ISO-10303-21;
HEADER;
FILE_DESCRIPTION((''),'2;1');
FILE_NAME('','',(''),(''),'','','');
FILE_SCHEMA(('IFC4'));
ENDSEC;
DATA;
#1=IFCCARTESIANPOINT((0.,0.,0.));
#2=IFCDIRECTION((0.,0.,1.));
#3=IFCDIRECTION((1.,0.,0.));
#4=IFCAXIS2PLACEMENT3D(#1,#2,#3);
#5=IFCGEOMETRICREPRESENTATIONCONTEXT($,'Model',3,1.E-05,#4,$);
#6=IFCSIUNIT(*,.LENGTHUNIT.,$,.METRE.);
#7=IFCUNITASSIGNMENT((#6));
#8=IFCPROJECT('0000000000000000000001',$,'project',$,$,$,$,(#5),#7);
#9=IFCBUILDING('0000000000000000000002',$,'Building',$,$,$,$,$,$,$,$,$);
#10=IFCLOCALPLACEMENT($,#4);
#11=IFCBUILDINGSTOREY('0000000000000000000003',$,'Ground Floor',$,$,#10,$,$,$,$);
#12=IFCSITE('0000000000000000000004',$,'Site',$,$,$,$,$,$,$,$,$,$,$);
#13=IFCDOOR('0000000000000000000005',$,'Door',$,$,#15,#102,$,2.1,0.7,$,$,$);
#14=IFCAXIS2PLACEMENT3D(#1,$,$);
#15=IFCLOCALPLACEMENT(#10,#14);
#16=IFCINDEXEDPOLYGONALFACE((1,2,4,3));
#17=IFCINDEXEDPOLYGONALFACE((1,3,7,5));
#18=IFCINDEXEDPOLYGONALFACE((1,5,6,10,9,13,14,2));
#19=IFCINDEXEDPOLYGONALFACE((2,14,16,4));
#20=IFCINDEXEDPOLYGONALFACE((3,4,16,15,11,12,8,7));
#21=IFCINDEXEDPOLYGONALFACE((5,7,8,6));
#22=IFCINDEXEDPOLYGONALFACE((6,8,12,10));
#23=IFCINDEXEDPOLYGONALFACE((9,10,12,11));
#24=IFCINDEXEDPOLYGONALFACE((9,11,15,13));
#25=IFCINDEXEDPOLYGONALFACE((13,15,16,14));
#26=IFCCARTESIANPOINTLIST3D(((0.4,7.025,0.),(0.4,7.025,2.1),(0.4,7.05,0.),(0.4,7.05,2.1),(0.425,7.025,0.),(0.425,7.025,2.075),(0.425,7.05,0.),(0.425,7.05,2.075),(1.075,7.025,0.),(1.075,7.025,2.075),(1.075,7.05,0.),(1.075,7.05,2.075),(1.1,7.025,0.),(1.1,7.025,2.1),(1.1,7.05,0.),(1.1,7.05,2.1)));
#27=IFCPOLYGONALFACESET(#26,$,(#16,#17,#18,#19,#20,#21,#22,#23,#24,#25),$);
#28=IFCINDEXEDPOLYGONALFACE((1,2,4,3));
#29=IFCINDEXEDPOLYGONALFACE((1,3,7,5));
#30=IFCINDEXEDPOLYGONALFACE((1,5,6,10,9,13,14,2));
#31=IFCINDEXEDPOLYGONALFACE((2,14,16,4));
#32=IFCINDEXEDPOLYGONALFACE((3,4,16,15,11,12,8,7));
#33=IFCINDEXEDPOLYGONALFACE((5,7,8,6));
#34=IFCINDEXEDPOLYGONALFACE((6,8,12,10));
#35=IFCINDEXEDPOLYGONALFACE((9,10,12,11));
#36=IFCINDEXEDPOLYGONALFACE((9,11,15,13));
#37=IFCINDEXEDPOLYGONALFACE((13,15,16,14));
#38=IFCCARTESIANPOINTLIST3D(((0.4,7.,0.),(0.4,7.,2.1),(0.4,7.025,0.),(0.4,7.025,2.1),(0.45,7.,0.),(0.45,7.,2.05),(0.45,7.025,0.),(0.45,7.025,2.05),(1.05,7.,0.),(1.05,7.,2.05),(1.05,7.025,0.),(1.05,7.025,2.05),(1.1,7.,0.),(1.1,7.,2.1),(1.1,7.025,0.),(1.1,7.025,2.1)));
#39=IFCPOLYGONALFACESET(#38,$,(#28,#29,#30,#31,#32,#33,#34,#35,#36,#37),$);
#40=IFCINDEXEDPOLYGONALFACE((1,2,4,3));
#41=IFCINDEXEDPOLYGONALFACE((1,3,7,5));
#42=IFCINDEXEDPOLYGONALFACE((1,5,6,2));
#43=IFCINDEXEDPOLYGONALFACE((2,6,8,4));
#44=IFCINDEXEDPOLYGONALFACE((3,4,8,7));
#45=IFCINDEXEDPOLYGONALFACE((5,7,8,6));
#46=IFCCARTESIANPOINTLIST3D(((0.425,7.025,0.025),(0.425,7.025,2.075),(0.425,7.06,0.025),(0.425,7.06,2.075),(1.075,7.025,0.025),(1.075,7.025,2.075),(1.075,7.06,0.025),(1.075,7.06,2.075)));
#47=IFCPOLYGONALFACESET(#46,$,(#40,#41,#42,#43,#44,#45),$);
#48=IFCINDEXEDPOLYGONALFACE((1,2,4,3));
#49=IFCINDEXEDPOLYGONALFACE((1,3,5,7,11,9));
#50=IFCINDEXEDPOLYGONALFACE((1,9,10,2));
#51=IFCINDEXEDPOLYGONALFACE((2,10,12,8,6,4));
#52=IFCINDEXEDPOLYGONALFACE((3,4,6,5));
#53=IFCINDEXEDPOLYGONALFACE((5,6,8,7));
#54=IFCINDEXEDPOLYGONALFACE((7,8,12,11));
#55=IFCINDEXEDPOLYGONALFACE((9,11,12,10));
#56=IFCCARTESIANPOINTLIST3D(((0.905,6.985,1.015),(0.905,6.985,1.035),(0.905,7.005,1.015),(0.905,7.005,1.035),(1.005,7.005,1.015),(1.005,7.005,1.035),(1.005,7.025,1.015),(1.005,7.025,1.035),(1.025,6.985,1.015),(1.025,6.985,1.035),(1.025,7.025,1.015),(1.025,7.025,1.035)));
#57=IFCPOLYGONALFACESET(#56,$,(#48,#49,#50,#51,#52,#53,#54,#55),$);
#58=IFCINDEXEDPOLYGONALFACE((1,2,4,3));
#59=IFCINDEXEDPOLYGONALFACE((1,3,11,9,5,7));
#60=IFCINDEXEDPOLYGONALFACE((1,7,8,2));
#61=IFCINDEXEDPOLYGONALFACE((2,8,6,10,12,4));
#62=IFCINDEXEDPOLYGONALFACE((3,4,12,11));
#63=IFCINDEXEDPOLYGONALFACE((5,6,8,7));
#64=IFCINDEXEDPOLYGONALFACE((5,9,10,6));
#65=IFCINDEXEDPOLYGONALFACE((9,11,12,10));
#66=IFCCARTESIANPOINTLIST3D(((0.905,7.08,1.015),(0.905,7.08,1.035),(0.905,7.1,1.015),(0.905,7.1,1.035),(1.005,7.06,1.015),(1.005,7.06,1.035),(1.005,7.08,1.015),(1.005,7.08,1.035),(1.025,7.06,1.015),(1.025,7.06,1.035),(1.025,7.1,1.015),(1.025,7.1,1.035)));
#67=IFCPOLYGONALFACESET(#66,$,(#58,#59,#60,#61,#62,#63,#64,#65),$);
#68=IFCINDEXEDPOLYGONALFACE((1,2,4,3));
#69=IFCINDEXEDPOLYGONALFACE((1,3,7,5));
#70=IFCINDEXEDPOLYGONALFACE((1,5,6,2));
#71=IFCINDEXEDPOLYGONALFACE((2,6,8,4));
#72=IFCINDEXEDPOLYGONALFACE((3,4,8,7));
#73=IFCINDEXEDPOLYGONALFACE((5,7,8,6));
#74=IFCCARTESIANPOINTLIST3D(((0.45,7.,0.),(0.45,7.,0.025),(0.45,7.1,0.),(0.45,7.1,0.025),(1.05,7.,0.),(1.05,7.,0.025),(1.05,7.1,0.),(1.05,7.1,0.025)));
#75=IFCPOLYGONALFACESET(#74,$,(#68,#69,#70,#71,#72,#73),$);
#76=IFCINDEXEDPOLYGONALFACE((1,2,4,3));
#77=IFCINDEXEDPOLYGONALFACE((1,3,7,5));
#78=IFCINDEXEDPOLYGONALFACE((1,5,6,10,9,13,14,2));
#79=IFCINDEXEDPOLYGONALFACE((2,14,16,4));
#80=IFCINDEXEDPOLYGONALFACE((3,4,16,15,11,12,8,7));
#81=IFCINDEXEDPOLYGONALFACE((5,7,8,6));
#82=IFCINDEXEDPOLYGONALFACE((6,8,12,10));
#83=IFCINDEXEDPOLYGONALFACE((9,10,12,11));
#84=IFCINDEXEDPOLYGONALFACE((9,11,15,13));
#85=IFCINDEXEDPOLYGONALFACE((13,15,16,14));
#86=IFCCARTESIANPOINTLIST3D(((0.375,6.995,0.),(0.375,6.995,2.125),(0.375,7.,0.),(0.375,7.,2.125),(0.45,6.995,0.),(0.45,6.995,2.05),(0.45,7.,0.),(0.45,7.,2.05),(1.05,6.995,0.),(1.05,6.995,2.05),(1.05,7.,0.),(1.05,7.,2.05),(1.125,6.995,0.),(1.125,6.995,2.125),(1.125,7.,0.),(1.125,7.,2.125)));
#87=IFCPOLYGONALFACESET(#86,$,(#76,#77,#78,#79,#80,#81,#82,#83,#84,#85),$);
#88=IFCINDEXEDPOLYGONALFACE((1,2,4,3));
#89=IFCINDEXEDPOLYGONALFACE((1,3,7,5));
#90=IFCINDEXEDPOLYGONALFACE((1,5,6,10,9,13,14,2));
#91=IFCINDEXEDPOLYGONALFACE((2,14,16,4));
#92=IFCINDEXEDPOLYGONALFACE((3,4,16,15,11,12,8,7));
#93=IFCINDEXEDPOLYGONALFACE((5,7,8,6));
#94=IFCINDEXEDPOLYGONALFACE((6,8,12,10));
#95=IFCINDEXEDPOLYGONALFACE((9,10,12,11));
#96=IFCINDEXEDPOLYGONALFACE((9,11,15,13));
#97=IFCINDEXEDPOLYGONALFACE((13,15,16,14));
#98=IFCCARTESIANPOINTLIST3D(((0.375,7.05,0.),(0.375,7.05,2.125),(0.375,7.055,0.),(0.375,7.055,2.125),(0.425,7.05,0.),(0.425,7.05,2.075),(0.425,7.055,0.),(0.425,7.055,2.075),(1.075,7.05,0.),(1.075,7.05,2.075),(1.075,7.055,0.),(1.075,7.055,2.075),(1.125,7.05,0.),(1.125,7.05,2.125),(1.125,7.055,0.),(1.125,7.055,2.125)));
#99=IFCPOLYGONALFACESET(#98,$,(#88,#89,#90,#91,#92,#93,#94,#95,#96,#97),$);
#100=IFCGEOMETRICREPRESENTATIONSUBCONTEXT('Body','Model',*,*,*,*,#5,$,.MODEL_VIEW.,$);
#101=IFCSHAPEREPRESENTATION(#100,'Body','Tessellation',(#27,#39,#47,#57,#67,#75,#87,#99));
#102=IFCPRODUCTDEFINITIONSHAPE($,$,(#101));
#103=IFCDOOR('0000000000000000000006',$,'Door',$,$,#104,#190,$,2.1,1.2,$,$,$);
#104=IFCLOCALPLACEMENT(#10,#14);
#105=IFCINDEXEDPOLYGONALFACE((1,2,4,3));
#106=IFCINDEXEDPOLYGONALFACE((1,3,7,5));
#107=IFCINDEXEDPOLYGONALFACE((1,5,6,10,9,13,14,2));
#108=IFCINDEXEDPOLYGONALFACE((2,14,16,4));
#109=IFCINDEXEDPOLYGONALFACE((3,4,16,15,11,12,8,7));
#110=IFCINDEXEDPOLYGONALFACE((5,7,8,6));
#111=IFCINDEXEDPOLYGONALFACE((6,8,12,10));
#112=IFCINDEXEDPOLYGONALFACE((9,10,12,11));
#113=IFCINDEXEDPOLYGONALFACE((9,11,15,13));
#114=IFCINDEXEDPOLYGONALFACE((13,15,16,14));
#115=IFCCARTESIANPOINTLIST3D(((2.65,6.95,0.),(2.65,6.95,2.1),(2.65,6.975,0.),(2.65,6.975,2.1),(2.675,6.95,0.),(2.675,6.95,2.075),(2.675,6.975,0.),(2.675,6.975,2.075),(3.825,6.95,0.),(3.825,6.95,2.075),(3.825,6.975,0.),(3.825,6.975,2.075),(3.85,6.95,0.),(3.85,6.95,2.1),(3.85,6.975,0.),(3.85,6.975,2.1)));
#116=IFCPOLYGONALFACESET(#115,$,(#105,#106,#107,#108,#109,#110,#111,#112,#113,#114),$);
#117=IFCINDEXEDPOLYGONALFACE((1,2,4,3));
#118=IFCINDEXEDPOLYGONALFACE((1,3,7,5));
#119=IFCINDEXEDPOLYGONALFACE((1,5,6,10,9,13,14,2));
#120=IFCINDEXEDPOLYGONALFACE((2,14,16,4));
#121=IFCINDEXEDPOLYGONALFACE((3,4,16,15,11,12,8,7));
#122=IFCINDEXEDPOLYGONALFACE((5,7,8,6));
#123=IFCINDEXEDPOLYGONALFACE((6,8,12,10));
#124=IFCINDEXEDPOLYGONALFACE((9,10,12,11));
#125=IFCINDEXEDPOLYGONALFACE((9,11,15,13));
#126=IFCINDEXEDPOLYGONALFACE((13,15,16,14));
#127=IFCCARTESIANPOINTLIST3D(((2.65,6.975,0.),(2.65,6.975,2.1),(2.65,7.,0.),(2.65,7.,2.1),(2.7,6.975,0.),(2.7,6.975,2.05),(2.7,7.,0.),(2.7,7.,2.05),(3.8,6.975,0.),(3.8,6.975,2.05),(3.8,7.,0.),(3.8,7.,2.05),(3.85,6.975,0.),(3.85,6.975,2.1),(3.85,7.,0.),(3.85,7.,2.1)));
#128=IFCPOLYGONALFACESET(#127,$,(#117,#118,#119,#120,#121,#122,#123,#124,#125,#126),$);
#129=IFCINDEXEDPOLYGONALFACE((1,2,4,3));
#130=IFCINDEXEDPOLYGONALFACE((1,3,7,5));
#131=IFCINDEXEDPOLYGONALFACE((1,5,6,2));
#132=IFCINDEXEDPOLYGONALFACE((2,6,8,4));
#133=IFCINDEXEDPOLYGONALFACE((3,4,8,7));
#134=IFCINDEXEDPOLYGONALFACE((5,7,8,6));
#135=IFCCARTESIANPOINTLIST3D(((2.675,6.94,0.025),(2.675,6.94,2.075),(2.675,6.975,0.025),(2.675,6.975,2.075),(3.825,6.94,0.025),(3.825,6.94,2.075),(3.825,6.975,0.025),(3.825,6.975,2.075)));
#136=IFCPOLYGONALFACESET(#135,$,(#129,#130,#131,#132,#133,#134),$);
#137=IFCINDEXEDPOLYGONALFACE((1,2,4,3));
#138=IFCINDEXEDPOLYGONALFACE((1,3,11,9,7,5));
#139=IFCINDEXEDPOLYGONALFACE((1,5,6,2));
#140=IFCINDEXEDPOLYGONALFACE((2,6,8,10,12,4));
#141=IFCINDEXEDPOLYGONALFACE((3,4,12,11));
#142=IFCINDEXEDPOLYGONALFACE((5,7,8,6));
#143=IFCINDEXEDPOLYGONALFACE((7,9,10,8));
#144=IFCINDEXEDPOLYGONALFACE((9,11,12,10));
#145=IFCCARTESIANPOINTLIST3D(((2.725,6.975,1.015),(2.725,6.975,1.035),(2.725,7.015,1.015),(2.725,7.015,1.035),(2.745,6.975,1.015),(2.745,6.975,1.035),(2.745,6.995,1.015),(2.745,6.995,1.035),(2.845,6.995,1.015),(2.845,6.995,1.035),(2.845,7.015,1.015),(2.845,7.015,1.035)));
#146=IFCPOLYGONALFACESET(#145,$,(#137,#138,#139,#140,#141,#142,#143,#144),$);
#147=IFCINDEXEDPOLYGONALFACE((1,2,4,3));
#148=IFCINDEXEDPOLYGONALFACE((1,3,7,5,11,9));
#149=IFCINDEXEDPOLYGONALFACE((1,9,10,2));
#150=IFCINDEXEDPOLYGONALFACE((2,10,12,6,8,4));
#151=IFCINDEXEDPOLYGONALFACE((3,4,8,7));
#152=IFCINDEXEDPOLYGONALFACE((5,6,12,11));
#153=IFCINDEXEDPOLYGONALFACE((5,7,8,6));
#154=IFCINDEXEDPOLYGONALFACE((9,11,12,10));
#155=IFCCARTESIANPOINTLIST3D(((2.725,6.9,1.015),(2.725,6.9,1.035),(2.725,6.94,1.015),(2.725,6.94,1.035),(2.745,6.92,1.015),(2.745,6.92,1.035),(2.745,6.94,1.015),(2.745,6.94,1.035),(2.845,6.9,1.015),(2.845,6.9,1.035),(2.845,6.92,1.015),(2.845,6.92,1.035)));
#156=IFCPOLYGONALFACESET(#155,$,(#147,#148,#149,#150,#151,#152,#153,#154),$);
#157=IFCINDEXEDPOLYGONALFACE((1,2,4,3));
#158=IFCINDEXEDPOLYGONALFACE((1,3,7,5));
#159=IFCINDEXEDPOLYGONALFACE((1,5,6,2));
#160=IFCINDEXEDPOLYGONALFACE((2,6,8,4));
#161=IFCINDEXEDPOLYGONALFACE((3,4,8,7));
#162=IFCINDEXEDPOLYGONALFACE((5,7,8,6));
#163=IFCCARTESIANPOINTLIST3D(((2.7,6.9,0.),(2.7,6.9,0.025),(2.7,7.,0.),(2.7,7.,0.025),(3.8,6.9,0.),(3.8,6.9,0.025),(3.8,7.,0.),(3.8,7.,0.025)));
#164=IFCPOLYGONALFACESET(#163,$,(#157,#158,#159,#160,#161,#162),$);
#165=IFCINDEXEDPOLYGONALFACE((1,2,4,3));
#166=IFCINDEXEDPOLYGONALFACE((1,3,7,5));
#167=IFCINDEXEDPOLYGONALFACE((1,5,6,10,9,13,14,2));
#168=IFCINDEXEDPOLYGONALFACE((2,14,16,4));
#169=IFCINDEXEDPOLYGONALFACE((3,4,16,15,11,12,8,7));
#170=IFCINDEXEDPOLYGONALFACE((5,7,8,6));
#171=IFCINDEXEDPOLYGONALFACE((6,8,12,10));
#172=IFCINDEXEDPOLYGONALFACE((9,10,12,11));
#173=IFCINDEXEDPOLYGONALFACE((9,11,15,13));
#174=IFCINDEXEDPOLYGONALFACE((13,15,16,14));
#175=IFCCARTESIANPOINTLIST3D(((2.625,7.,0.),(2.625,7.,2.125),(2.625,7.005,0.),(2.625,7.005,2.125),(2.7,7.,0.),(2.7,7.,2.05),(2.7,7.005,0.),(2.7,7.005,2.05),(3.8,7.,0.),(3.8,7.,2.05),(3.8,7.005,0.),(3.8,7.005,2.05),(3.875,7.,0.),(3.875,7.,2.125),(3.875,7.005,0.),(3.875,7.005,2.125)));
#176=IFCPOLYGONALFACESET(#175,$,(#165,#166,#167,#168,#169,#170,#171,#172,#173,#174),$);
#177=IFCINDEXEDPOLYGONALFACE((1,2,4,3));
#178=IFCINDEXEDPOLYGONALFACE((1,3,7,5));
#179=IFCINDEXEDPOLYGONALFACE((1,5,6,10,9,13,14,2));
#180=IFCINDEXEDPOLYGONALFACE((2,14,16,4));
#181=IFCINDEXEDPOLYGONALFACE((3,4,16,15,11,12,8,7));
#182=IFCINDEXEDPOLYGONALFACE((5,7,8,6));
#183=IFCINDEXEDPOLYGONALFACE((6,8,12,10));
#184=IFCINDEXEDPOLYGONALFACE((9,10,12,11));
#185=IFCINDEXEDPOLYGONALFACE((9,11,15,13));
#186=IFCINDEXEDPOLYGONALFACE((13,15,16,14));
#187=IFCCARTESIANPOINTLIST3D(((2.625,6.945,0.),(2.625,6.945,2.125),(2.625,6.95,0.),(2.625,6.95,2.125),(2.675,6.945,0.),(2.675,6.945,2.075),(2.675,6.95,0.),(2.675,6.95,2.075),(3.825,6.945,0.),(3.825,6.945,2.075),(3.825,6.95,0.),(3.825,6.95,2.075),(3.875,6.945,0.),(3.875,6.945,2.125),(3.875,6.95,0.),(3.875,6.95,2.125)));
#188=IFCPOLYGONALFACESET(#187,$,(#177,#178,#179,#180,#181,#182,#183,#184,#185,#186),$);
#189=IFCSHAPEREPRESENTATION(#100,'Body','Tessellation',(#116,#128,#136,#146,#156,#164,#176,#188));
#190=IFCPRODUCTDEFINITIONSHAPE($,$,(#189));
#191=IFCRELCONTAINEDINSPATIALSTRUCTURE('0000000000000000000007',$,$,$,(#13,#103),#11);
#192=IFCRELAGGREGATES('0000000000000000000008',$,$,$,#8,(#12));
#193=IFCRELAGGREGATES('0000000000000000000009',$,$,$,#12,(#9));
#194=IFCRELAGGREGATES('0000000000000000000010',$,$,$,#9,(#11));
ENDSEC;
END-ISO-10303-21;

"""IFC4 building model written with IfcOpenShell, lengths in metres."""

from ifc_helpers import new_model, si_unit, frame, origin_with_axes, place, context, subcontext, project, spatial, line, indexed_curve, outline, extrude, element, save


model = new_model("IFC4")

# Units and contexts
model_context = context("Model", 3, precision=1e-05, world=origin_with_axes())
body_context = subcontext(model_context, "Body", "Model", "MODEL_VIEW")
ifc_project = project(units=[si_unit("LENGTHUNIT", "METRE")], contexts=[model_context])

# Site, building, storey
site = spatial("IfcSite", under=ifc_project, Name="Site")
building = spatial("IfcBuilding", under=site, Name="Building")
storey_placement = place(None, origin_with_axes())
storey = spatial("IfcBuildingStorey", under=building, at=storey_placement, Name="Ground Floor")

# Doors
door_1_placement = place(storey_placement, frame((0.4, 7.0, 0.0), z_axis=(0.0, 0.0, 1.0), x_axis=(1.0, 0.0, 0.0)))
element("IfcDoor", 1, at=door_1_placement, inside=storey, Name="Door", OverallHeight=2.1, OverallWidth=0.7, context=body_context, shape_type="SweptSolid", body=[
    extrude(outline(indexed_curve([(0.0, 0.0), (0.0, 2.1), (0.7, 2.1), (0.7, 0.0), (0.675, 0.0), (0.675, 2.075), (0.025, 2.075), (0.025, 0.0)], segments=[line(1, 2, 3, 4, 5, 6, 7, 8, 1)])), frame((0.0, 0.025, 0.0), z_axis=(0.0, -1.0, 0.0), x_axis=(1.0, 0.0, 0.0)), (0.0, 0.0, -1.0), 0.025),
    extrude(outline(indexed_curve([(0.0, 0.0), (0.0, 2.1), (0.7, 2.1), (0.7, 0.0), (0.65, 0.0), (0.65, 2.05), (0.05, 2.05), (0.05, 0.0)], segments=[line(1, 2, 3, 4, 5, 6, 7, 8, 1)])), frame((0.0, 0.0, 0.0), z_axis=(0.0, -1.0, 0.0), x_axis=(1.0, 0.0, 0.0)), (0.0, 0.0, -1.0), 0.025),
    extrude(outline(indexed_curve([(0.0, 0.0), (0.65, 0.0), (0.65, 0.035), (0.0, 0.035)], segments=[line(1, 2, 3, 4, 1)])), frame((0.025, 0.025, 0.025), z_axis=(0.0, 0.0, 1.0), x_axis=(1.0, 0.0, 0.0)), (0.0, 0.0, 1.0), 2.05),
    extrude(outline(indexed_curve([(0.0, 0.0), (0.0, -0.04), (-0.12, -0.04), (-0.12, -0.02), (-0.02, -0.02), (-0.02, 0.0)], segments=[line(1, 2, 3, 4, 5, 6, 1)])), frame((0.625, 0.025, 1.015), z_axis=(0.0, 0.0, 1.0), x_axis=(1.0, 0.0, 0.0)), (0.0, 0.0, 1.0), 0.02),
    extrude(outline(indexed_curve([(0.0, 0.0), (0.0, 0.04), (-0.12, 0.04), (-0.12, 0.02), (-0.02, 0.02), (-0.02, 0.0)], segments=[line(1, 2, 3, 4, 5, 6, 1)])), frame((0.625, 0.06, 1.015), z_axis=(0.0, 0.0, 1.0), x_axis=(1.0, 0.0, 0.0)), (0.0, 0.0, 1.0), 0.02),
    extrude(outline(indexed_curve([(0.0, 0.0), (0.6, 0.0), (0.6, 0.1), (0.0, 0.1)], segments=[line(1, 2, 3, 4, 1)])), frame((0.05, 0.0, 0.0), z_axis=(0.0, 0.0, 1.0), x_axis=(1.0, 0.0, 0.0)), (0.0, 0.0, 1.0), 0.025),
    extrude(outline(indexed_curve([(0.0, 0.0), (0.0, 2.125), (0.75, 2.125), (0.75, 0.0), (0.675, 0.0), (0.675, 2.05), (0.075, 2.05), (0.075, 0.0)], segments=[line(1, 2, 3, 4, 5, 6, 7, 8, 1)])), frame((-0.025, -0.005, 0.0), z_axis=(0.0, -1.0, 0.0), x_axis=(1.0, 0.0, 0.0)), (0.0, 0.0, -1.0), 0.005),
    extrude(outline(indexed_curve([(0.0, 0.0), (0.0, 2.125), (0.75, 2.125), (0.75, 0.0), (0.7, 0.0), (0.7, 2.075), (0.05, 2.075), (0.05, 0.0)], segments=[line(1, 2, 3, 4, 5, 6, 7, 8, 1)])), frame((-0.025, 0.05, 0.0), z_axis=(0.0, -1.0, 0.0), x_axis=(1.0, 0.0, 0.0)), (0.0, 0.0, -1.0), 0.005),
])
door_2_placement = place(storey_placement, frame((3.85, 7.0, 0.0), z_axis=(0.0, 0.0, 1.0), x_axis=(-1.0, 0.0, 0.0)))
element("IfcDoor", 2, at=door_2_placement, inside=storey, Name="Door", OverallHeight=2.1, OverallWidth=1.2, context=body_context, shape_type="SweptSolid", body=[
    extrude(outline(indexed_curve([(0.0, 0.0), (0.0, 2.1), (1.2, 2.1), (1.2, 0.0), (1.175, 0.0), (1.175, 2.075), (0.025, 2.075), (0.025, 0.0)], segments=[line(1, 2, 3, 4, 5, 6, 7, 8, 1)])), frame((0.0, 0.025, 0.0), z_axis=(0.0, -1.0, 0.0), x_axis=(1.0, 0.0, 0.0)), (0.0, 0.0, -1.0), 0.025),
    extrude(outline(indexed_curve([(0.0, 0.0), (0.0, 2.1), (1.2, 2.1), (1.2, 0.0), (1.15, 0.0), (1.15, 2.05), (0.05, 2.05), (0.05, 0.0)], segments=[line(1, 2, 3, 4, 5, 6, 7, 8, 1)])), frame((0.0, 0.0, 0.0), z_axis=(0.0, -1.0, 0.0), x_axis=(1.0, 0.0, 0.0)), (0.0, 0.0, -1.0), 0.025),
    extrude(outline(indexed_curve([(0.0, 0.0), (1.15, 0.0), (1.15, 0.035), (0.0, 0.035)], segments=[line(1, 2, 3, 4, 1)])), frame((0.025, 0.025, 0.025), z_axis=(0.0, 0.0, 1.0), x_axis=(1.0, 0.0, 0.0)), (0.0, 0.0, 1.0), 2.05),
    extrude(outline(indexed_curve([(0.0, 0.0), (0.0, -0.04), (-0.12, -0.04), (-0.12, -0.02), (-0.02, -0.02), (-0.02, 0.0)], segments=[line(1, 2, 3, 4, 5, 6, 1)])), frame((1.125, 0.025, 1.015), z_axis=(0.0, 0.0, 1.0), x_axis=(1.0, 0.0, 0.0)), (0.0, 0.0, 1.0), 0.02),
    extrude(outline(indexed_curve([(0.0, 0.0), (0.0, 0.04), (-0.12, 0.04), (-0.12, 0.02), (-0.02, 0.02), (-0.02, 0.0)], segments=[line(1, 2, 3, 4, 5, 6, 1)])), frame((1.125, 0.06, 1.015), z_axis=(0.0, 0.0, 1.0), x_axis=(1.0, 0.0, 0.0)), (0.0, 0.0, 1.0), 0.02),
    extrude(outline(indexed_curve([(0.0, 0.0), (1.1, 0.0), (1.1, 0.1), (0.0, 0.1)], segments=[line(1, 2, 3, 4, 1)])), frame((0.05, 0.0, 0.0), z_axis=(0.0, 0.0, 1.0), x_axis=(1.0, 0.0, 0.0)), (0.0, 0.0, 1.0), 0.025),
    extrude(outline(indexed_curve([(0.0, 0.0), (0.0, 2.125), (1.25, 2.125), (1.25, 0.0), (1.175, 0.0), (1.175, 2.05), (0.075, 2.05), (0.075, 0.0)], segments=[line(1, 2, 3, 4, 5, 6, 7, 8, 1)])), frame((-0.025, -0.005, 0.0), z_axis=(0.0, -1.0, 0.0), x_axis=(1.0, 0.0, 0.0)), (0.0, 0.0, -1.0), 0.005),
    extrude(outline(indexed_curve([(0.0, 0.0), (0.0, 2.125), (1.25, 2.125), (1.25, 0.0), (1.2, 0.0), (1.2, 2.075), (0.05, 2.075), (0.05, 0.0)], segments=[line(1, 2, 3, 4, 5, 6, 7, 8, 1)])), frame((-0.025, 0.05, 0.0), z_axis=(0.0, -1.0, 0.0), x_axis=(1.0, 0.0, 0.0)), (0.0, 0.0, -1.0), 0.005),
])

save(model, "model.ifc")
